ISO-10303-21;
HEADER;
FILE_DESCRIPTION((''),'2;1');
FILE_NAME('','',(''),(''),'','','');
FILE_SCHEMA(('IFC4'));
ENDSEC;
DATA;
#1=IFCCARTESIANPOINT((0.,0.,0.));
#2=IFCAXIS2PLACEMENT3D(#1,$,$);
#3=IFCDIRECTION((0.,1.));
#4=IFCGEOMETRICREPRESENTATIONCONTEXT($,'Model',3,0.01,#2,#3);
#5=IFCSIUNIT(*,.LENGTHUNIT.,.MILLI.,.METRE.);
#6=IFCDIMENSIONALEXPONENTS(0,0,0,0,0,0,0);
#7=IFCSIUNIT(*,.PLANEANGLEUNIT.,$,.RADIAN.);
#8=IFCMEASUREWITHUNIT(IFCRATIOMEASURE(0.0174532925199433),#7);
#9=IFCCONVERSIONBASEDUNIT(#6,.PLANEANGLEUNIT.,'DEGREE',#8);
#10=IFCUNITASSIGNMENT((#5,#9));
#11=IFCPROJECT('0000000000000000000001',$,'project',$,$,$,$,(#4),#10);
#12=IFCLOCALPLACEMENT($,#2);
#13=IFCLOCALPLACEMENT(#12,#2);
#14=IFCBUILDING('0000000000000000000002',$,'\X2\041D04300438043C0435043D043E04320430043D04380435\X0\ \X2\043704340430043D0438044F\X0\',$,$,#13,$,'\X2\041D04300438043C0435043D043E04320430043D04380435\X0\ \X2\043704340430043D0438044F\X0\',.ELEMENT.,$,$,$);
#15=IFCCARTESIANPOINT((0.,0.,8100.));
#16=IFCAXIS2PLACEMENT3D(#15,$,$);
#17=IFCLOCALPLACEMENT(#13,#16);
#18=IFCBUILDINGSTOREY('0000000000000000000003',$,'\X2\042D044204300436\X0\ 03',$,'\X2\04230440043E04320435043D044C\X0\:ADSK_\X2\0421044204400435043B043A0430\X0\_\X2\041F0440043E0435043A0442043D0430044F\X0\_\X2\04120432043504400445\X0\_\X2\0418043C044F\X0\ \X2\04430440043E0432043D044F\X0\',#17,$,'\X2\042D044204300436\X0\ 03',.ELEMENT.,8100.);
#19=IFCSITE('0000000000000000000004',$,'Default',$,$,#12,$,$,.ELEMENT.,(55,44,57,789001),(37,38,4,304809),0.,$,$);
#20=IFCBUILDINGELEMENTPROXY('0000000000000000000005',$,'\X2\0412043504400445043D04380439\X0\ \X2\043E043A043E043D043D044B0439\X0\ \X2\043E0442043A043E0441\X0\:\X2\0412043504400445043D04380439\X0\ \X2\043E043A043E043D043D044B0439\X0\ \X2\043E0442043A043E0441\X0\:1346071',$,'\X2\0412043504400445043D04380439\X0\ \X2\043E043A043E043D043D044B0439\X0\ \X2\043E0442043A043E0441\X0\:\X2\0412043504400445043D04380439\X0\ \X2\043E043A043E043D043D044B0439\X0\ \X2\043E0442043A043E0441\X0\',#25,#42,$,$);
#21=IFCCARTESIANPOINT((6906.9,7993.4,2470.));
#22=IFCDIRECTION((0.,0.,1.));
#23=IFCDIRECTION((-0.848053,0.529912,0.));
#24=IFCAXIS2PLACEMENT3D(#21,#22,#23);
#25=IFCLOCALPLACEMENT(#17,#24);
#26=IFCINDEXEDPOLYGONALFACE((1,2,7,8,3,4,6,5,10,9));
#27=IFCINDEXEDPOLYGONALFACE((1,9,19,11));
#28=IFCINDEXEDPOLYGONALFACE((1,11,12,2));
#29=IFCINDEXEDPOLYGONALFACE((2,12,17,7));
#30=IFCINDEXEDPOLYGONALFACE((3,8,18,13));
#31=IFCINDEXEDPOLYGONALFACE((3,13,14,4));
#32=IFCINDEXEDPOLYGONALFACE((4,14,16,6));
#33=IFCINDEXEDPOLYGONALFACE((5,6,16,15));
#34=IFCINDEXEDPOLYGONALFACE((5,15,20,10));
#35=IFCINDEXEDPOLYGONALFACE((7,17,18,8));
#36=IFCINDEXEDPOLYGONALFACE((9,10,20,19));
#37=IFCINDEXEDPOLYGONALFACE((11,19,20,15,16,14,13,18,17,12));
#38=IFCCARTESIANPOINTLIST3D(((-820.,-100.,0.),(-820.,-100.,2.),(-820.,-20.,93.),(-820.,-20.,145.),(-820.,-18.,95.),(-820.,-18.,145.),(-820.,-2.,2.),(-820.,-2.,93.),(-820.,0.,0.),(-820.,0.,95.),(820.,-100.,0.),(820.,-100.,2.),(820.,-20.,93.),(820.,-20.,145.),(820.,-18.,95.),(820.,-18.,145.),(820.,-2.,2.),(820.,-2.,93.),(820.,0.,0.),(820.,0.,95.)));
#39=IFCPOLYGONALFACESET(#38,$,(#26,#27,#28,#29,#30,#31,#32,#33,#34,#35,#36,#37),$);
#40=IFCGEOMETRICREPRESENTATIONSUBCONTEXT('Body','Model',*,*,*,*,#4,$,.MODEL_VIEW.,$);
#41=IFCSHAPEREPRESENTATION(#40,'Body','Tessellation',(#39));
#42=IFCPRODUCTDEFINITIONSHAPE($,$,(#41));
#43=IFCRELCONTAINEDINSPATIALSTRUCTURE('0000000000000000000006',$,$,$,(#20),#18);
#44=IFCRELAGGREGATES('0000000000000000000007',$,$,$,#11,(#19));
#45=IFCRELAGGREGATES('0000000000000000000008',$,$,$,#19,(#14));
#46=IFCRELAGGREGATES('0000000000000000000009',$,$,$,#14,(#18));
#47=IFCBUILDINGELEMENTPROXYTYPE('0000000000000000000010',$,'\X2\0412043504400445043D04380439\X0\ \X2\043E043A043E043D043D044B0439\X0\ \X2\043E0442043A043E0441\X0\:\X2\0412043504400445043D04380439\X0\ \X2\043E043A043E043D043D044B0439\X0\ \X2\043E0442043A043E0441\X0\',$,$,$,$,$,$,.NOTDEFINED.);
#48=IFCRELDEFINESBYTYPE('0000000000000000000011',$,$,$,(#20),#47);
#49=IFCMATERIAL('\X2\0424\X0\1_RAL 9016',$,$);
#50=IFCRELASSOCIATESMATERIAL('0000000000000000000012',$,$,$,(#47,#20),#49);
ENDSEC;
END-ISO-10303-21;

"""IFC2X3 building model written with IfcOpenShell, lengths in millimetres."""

from ifc_helpers import new_model, entity, si_unit, converted_unit, direction, frame, origin, place, context, subcontext, project, spatial, polyline, outline, extrude, source, transform, mapped, material, type_object, type_shapes, element, save


model = new_model("IFC2X3")

# Units and contexts
model_context = context("Model", 3, precision=0.01, world=origin(), true_north=direction((0.0, 1.0)))
body_context = subcontext(model_context, "Body", "Model", "MODEL_VIEW")
ifc_project = project(units=[si_unit("LENGTHUNIT", "METRE", prefix="MILLI"), converted_unit("PLANEANGLEUNIT", "DEGREE", entity("IfcRatioMeasure", 0.0174532925199433), si_unit("PLANEANGLEUNIT", "RADIAN"), dimensions=[0, 0, 0, 0, 0, 0, 0])], contexts=[model_context])

# Site, building, storey
site_placement = place(None, origin())
site = spatial("IfcSite", under=ifc_project, at=site_placement, Name="Default", CompositionType="ELEMENT", RefLatitude=(55, 44, 57, 789001), RefLongitude=(37, 38, 4, 304809), RefElevation=0.0)
building_placement = place(site_placement, origin())
building = spatial("IfcBuilding", under=site, at=building_placement, Name="Наименование здания", LongName="Наименование здания", CompositionType="ELEMENT")
storey_placement = place(building_placement, frame((0.0, 0.0, 8100.0)))
storey = spatial("IfcBuildingStorey", under=building, at=storey_placement, Name="Этаж 03", ObjectType="Уровень:ADSK_Стрелка_Проектная_Вверх_Имя уровня", LongName="Этаж 03", CompositionType="ELEMENT", Elevation=8100.0)

# Building element proxy
ifc_material_1 = material(Name="Ф1_RAL 9016")
building_element_proxy_type_1 = type_object("IfcBuildingElementProxyType", Name="Верхний оконный откос:Верхний оконный откос", PredefinedType="NOTDEFINED", material=ifc_material_1)
shared_shape_1 = source(origin(), body_context, "Body", "SweptSolid", [
    extrude(outline(polyline([(28.0, -10.0), (78.0, -10.0), (78.0, -8.0), (26.0, -8.0), (26.0, -26.0), (-65.0, -26.0), (-65.0, 72.0), (-67.0, 72.0), (-67.0, -28.0), (28.0, -28.0), (28.0, -10.0)])), frame((-820.0, -28.0, 67.0), z_axis=(1.0, 0.0, 0.0), x_axis=(0.0, 0.0, 1.0)), (0.0, 0.0, 1.0), 1640.0),
])
type_shapes(building_element_proxy_type_1, [shared_shape_1])
proxy_1_placement = place(storey_placement, frame((6906.9, 7993.4, 2470.0), z_axis=(0.0, 0.0, 1.0), x_axis=(-0.848053, 0.529912, 0.0)))
element("IfcBuildingElementProxy", 1, at=proxy_1_placement, inside=storey, type_object=building_element_proxy_type_1, material=ifc_material_1, Name="Верхний оконный откос:Верхний оконный откос:1346071", ObjectType="Верхний оконный откос:Верхний оконный откос", context=body_context, shape_type="MappedRepresentation", body=[
    mapped(shared_shape_1, transform((0.0, 0.0, 0.0), scale=1.0)),
])

save(model, "model.ifc")
